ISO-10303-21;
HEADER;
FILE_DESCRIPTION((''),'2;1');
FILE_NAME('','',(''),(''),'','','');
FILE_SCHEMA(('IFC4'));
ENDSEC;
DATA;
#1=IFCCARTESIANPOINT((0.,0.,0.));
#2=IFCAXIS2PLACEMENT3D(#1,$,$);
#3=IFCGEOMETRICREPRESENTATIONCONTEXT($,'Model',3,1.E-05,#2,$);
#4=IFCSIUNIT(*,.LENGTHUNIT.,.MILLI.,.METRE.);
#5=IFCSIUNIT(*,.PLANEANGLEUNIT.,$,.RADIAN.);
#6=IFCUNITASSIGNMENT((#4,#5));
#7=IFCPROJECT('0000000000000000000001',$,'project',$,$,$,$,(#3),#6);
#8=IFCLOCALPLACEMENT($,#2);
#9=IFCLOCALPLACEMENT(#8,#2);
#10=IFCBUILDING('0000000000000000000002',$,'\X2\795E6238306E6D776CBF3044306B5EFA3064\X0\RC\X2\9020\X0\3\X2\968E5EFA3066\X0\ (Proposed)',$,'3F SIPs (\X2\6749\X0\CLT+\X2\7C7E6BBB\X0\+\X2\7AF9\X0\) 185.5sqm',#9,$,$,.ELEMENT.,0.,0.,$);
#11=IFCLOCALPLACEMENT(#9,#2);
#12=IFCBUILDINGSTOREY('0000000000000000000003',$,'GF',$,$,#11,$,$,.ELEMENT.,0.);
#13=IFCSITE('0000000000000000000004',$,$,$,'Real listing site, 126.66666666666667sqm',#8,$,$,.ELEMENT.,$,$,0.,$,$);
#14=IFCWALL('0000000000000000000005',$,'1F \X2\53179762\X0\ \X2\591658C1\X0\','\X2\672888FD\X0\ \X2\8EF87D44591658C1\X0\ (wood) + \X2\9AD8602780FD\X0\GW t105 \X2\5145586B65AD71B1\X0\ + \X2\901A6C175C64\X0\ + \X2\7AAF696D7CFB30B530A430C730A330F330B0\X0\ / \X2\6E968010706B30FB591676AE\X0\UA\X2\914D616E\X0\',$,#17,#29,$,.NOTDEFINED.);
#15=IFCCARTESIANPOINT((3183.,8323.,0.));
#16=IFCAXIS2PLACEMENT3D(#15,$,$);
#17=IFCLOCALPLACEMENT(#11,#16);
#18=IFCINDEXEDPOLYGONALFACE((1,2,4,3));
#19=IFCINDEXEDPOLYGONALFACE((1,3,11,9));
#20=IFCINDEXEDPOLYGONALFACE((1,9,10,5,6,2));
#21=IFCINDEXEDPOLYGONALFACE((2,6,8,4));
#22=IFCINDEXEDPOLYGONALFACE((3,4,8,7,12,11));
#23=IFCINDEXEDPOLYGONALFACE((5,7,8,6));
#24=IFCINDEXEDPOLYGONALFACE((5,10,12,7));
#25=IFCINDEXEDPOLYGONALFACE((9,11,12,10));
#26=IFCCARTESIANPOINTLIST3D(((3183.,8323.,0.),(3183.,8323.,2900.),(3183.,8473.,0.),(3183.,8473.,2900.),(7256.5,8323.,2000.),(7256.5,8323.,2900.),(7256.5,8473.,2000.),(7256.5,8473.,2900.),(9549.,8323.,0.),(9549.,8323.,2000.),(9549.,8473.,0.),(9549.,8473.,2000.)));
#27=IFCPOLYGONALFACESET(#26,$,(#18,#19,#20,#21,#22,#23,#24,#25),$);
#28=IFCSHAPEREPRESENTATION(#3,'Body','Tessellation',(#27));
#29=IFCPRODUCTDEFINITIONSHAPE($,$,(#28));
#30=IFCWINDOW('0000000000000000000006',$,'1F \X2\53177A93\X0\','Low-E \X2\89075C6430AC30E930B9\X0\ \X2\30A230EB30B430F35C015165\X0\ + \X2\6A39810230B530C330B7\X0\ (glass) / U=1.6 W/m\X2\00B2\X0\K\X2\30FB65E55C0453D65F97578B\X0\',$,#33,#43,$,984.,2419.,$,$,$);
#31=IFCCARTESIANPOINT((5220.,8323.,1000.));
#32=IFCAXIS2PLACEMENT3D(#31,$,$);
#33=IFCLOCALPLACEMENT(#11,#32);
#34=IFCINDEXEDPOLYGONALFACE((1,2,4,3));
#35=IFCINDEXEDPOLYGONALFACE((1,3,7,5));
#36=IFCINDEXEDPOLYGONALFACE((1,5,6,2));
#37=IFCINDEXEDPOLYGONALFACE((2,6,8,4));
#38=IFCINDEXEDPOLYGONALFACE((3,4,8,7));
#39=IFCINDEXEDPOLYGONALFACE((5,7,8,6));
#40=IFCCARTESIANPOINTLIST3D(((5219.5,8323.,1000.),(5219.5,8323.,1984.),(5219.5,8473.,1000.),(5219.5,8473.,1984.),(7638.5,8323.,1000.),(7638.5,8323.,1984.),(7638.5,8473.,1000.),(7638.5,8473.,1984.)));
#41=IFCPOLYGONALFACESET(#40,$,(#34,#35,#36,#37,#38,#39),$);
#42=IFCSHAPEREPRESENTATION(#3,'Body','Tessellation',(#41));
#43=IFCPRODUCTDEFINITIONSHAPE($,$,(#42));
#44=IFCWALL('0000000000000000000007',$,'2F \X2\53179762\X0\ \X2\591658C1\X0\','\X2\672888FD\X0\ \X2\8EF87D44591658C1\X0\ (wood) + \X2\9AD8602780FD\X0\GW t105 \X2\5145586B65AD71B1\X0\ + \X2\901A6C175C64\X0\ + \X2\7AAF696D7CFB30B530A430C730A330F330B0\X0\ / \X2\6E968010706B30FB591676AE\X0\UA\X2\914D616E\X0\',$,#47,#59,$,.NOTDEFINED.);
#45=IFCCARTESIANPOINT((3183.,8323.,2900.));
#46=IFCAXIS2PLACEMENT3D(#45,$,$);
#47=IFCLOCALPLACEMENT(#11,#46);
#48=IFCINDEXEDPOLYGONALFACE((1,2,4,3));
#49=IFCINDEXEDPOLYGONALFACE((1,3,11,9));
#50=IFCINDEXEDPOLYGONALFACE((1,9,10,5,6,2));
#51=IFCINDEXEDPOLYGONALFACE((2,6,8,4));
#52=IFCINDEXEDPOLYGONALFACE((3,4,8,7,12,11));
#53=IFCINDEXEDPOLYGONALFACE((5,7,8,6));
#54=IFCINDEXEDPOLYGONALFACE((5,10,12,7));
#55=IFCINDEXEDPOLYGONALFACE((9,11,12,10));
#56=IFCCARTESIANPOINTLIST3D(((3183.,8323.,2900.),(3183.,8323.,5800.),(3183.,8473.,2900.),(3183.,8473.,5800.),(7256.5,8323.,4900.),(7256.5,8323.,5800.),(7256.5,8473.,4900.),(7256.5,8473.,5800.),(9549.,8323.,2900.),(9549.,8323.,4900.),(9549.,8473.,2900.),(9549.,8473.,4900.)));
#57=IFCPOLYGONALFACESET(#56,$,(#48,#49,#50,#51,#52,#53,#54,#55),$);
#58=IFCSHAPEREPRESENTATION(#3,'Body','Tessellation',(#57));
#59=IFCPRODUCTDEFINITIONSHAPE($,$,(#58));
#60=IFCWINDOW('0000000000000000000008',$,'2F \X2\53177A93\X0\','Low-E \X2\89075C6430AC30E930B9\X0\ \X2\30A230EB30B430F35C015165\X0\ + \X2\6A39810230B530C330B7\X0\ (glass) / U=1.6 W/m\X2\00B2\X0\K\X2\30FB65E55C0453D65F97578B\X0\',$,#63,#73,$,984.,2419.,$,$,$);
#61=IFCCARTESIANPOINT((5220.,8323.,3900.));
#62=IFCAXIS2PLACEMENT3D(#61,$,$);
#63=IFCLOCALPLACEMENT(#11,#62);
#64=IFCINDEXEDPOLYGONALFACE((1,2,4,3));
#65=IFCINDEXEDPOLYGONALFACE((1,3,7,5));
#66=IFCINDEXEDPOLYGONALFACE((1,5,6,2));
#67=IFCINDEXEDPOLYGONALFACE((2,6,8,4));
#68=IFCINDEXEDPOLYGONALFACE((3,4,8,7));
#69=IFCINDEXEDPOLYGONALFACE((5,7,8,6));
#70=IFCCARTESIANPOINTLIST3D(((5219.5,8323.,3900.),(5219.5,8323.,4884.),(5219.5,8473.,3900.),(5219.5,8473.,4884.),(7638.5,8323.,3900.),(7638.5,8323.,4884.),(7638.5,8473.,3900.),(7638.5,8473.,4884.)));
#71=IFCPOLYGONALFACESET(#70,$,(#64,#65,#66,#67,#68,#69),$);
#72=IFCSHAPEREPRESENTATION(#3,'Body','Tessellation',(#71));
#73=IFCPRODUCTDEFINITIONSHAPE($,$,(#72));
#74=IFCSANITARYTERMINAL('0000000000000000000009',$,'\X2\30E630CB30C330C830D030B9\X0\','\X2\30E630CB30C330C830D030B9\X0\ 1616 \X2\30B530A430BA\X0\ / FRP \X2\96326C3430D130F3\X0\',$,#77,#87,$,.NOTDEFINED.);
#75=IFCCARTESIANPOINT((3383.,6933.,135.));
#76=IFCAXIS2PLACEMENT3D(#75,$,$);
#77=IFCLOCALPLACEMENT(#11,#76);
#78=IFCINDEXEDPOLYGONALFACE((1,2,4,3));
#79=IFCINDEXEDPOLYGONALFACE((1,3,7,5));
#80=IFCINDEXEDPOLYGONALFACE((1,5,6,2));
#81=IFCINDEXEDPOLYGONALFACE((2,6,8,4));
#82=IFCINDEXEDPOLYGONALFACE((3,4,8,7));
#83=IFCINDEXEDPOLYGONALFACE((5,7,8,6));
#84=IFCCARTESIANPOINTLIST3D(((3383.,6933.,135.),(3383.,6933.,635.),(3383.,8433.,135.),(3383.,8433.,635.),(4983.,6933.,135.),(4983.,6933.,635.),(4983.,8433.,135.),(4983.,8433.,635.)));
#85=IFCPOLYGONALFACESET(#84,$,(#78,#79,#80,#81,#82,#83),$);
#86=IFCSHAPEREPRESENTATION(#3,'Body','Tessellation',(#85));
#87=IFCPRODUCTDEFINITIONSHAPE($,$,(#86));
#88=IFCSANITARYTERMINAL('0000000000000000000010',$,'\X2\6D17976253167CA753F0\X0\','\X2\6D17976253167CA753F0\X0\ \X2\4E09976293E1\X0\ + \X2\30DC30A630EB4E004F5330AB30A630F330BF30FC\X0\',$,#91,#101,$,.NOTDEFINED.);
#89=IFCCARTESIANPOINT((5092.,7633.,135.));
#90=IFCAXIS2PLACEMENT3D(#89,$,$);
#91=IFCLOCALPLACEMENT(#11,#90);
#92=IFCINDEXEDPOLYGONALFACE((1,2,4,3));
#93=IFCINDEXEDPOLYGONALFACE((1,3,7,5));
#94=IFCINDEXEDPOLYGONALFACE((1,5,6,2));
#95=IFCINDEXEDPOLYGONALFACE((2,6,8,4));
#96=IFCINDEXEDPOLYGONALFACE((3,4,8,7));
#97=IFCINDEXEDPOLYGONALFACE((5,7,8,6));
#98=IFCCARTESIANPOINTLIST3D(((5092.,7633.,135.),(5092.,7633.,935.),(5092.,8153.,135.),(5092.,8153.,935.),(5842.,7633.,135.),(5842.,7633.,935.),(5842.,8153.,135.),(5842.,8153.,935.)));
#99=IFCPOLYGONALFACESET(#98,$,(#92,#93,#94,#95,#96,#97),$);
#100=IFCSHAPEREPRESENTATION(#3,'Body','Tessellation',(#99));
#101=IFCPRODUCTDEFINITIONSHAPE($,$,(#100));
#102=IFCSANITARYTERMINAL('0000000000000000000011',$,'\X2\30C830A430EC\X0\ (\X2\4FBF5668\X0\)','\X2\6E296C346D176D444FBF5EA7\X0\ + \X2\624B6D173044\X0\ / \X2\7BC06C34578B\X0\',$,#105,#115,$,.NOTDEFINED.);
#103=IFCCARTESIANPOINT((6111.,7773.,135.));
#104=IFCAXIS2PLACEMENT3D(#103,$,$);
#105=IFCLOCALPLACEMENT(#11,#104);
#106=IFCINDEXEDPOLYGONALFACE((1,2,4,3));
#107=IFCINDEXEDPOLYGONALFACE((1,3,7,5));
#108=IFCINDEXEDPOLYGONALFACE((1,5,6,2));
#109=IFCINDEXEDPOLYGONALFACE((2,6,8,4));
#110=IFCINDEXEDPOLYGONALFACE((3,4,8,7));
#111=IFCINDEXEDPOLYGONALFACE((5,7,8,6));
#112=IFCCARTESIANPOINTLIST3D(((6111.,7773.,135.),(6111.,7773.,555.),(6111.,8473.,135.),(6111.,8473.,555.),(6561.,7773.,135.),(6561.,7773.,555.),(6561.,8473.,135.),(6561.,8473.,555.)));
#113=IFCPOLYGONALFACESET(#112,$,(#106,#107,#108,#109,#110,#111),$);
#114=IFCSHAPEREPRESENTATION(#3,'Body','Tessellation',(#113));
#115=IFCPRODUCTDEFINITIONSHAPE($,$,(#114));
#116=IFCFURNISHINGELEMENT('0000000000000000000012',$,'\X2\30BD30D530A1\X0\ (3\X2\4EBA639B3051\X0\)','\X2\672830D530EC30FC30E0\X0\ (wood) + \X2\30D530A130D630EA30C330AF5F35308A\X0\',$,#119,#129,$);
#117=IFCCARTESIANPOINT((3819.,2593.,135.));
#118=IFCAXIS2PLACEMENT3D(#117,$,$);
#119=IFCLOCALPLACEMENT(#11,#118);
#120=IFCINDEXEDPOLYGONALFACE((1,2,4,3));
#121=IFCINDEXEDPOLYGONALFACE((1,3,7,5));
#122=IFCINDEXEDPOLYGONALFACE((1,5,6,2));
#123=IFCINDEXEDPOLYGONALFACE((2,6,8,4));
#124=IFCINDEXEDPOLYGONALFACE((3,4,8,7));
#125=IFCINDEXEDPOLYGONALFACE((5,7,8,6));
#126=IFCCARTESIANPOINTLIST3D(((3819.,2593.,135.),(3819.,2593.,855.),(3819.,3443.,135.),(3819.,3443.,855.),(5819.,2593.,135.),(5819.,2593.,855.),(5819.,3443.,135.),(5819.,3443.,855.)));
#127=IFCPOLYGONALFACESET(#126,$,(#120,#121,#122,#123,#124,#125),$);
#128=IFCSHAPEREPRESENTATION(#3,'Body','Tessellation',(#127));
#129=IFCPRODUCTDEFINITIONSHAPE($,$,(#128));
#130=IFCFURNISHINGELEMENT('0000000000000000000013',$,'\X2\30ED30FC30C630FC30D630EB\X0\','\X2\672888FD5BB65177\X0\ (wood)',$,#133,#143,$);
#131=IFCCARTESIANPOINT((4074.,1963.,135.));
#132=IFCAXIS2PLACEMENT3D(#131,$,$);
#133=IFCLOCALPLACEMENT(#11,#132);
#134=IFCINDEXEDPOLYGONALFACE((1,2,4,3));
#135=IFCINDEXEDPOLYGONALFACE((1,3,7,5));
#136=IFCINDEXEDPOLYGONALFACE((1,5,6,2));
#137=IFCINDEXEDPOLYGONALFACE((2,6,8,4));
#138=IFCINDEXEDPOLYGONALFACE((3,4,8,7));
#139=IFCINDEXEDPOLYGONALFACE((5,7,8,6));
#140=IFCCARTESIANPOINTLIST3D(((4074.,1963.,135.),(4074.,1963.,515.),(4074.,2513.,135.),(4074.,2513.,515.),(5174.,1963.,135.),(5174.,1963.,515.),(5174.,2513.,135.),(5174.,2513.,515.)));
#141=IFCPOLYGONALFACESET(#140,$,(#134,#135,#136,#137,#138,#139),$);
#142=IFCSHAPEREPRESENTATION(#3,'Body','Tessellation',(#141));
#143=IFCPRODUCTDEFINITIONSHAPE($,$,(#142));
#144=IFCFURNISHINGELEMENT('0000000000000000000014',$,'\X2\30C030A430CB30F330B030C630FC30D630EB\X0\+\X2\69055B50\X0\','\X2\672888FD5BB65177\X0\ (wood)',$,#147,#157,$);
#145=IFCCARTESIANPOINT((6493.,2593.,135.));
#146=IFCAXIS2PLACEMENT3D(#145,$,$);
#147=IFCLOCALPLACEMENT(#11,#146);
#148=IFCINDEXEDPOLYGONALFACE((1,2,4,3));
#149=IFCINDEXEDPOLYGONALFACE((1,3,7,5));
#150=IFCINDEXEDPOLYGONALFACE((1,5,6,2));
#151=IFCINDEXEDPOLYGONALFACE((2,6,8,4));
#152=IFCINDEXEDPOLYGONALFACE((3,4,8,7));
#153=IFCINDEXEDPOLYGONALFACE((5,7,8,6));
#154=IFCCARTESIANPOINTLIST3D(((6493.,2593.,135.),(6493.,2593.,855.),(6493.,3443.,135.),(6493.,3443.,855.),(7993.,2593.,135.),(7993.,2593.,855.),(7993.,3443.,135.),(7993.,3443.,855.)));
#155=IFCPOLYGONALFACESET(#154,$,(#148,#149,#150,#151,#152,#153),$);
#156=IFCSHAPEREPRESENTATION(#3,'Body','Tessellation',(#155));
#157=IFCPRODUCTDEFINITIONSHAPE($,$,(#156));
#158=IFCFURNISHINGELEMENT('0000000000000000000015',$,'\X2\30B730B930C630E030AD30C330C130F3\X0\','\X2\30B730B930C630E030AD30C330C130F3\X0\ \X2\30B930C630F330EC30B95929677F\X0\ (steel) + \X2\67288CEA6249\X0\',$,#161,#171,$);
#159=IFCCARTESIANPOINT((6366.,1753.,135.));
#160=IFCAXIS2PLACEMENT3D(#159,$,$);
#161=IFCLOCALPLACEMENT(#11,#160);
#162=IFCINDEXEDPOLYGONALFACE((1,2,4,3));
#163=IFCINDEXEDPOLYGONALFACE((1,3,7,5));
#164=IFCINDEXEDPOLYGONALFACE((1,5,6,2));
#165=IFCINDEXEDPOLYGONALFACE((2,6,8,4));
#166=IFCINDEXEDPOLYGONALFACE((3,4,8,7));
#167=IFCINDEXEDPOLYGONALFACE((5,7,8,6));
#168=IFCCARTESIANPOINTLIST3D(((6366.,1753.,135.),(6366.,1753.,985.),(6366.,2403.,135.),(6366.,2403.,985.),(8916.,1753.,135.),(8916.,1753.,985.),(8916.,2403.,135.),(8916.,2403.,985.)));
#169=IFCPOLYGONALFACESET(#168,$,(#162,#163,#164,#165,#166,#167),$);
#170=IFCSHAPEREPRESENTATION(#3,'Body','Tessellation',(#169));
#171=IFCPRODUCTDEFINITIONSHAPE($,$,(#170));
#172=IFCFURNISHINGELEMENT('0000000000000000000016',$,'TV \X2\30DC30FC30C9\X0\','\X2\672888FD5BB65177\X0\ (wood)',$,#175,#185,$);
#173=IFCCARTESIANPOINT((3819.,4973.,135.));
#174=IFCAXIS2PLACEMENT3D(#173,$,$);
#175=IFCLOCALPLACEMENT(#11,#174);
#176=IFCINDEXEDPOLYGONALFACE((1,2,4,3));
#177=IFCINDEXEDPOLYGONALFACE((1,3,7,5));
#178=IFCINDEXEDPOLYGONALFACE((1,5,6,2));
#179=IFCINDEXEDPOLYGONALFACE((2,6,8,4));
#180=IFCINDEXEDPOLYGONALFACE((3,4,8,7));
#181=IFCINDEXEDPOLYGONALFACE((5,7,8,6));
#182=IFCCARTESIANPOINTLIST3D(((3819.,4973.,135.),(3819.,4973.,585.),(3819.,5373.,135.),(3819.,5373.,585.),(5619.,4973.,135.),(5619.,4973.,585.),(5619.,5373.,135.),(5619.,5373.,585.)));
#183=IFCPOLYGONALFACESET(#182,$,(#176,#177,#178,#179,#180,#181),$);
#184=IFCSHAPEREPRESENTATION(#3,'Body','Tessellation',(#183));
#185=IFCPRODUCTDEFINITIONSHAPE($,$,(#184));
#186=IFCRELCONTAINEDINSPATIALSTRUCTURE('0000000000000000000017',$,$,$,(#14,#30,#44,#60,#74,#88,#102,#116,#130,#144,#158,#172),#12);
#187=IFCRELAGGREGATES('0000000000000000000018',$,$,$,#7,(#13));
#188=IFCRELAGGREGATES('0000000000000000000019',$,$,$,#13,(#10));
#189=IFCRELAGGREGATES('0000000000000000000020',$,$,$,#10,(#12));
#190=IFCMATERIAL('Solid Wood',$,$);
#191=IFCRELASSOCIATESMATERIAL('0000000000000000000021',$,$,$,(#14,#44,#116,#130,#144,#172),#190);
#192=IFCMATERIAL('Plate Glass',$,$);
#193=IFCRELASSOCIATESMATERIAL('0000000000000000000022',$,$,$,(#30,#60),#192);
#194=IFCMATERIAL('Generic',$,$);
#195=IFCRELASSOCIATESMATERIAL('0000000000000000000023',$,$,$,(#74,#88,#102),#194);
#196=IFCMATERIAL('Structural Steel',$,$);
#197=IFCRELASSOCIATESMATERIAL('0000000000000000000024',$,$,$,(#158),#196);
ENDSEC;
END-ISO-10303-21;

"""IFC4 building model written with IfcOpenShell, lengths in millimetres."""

from ifc_helpers import new_model, si_unit, frame, frame_2d, origin, place, context, project, spatial, rectangle, extrude, material, element, fill, save


model = new_model("IFC4")

# Units and contexts
model_context = context("Model", 3, precision=1e-05, world=origin())
ifc_project = project(units=[si_unit("LENGTHUNIT", "METRE", prefix="MILLI"), si_unit("PLANEANGLEUNIT", "RADIAN")], contexts=[model_context])

# Site, building, storey
site_placement = place(None, origin())
site = spatial("IfcSite", under=ifc_project, at=site_placement, ObjectType="Real listing site, 126.66666666666667sqm", CompositionType="ELEMENT", RefElevation=0.0)
building_placement = place(site_placement, origin())
building = spatial("IfcBuilding", under=site, at=building_placement, Name="神戸の海沿いに建つRC造3階建て (Proposed)", ObjectType="3F SIPs (杉CLT+籾殻+竹) 185.5sqm", CompositionType="ELEMENT", ElevationOfRefHeight=0.0, ElevationOfTerrain=0.0)
storey_placement = place(building_placement, origin())
storey = spatial("IfcBuildingStorey", under=building, at=storey_placement, Name="GF", CompositionType="ELEMENT", Elevation=0.0)

# Wall, opening, window
ifc_material_1 = material(Name="Solid Wood")
wall_1_placement = place(storey_placement, frame((3183.0, 8323.0, 0.0)))
wall_1 = element("IfcWall", 1, at=wall_1_placement, inside=storey, material=ifc_material_1, Name="1F 北面 外壁", Description="木製 軸組外壁 (wood) + 高性能GW t105 充填断熱 + 通気層 + 窯業系サイディング / 準耐火・外皮UA配慮", PredefinedType="NOTDEFINED", context=model_context, shape_type="SweptSolid", body=[
    extrude(rectangle(XDim=6366.0, YDim=150.0, at=frame_2d((3183.0, 75.0))), frame((3183.0, 8323.0, 0.0)), (0.0, 0.0, 1.0), 2900.0),
])
opening_1_placement = place(storey_placement, frame((5220.0, 8323.0, 1000.0)))
opening_1 = element("IfcOpeningElement", 2, at=opening_1_placement, cuts=wall_1, PredefinedType="NOTDEFINED", context=model_context, shape_type="SweptSolid", body=[
    extrude(rectangle(XDim=2419.0, YDim=150.0, at=frame_2d((1209.0, 75.0))), frame((5220.0, 8323.0, 1000.0)), (0.0, 0.0, 1.0), 984.0),
])
ifc_material_2 = material(Name="Plate Glass")
window_1_placement = place(storey_placement, frame((5220.0, 8323.0, 1000.0)))
window_1 = element("IfcWindow", 3, at=window_1_placement, inside=storey, material=ifc_material_2, Name="1F 北窓", Description="Low-E 複層ガラス アルゴン封入 + 樹脂サッシ (glass) / U=1.6 W/m²K・日射取得型", OverallHeight=984.0, OverallWidth=2419.0, context=model_context, shape_type="SweptSolid", body=[
    extrude(rectangle(XDim=2419.0, YDim=150.0, at=frame_2d((1209.0, 75.0))), frame((5220.0, 8323.0, 1000.0)), (0.0, 0.0, 1.0), 984.0),
])
fill(opening_1, window_1)

# Wall, opening, window
wall_2_placement = place(storey_placement, frame((3183.0, 8323.0, 2900.0)))
wall_2 = element("IfcWall", 4, at=wall_2_placement, inside=storey, material=ifc_material_1, Name="2F 北面 外壁", Description="木製 軸組外壁 (wood) + 高性能GW t105 充填断熱 + 通気層 + 窯業系サイディング / 準耐火・外皮UA配慮", PredefinedType="NOTDEFINED", context=model_context, shape_type="SweptSolid", body=[
    extrude(rectangle(XDim=6366.0, YDim=150.0, at=frame_2d((3183.0, 75.0))), frame((3183.0, 8323.0, 2900.0)), (0.0, 0.0, 1.0), 2900.0),
])
opening_2_placement = place(storey_placement, frame((5220.0, 8323.0, 3900.0)))
opening_2 = element("IfcOpeningElement", 5, at=opening_2_placement, cuts=wall_2, PredefinedType="NOTDEFINED", context=model_context, shape_type="SweptSolid", body=[
    extrude(rectangle(XDim=2419.0, YDim=150.0, at=frame_2d((1209.0, 75.0))), frame((5220.0, 8323.0, 3900.0)), (0.0, 0.0, 1.0), 984.0),
])
window_2_placement = place(storey_placement, frame((5220.0, 8323.0, 3900.0)))
window_2 = element("IfcWindow", 6, at=window_2_placement, inside=storey, material=ifc_material_2, Name="2F 北窓", Description="Low-E 複層ガラス アルゴン封入 + 樹脂サッシ (glass) / U=1.6 W/m²K・日射取得型", OverallHeight=984.0, OverallWidth=2419.0, context=model_context, shape_type="SweptSolid", body=[
    extrude(rectangle(XDim=2419.0, YDim=150.0, at=frame_2d((1209.0, 75.0))), frame((5220.0, 8323.0, 3900.0)), (0.0, 0.0, 1.0), 984.0),
])
fill(opening_2, window_2)

# Sanitary terminals
ifc_material_3 = material(Name="Generic")
sanitary_terminal_1_placement = place(storey_placement, frame((3383.0, 6933.0, 135.0)))
element("IfcSanitaryTerminal", 7, at=sanitary_terminal_1_placement, inside=storey, material=ifc_material_3, Name="ユニットバス", Description="ユニットバス 1616 サイズ / FRP 防水パン", PredefinedType="NOTDEFINED", context=model_context, shape_type="SweptSolid", body=[
    extrude(rectangle(XDim=1600.0, YDim=1500.0, at=frame_2d((800.0, 750.0))), frame((3383.0, 6933.0, 135.0)), (0.0, 0.0, 1.0), 500.0),
])
sanitary_terminal_2_placement = place(storey_placement, frame((5092.0, 7633.0, 135.0)))
element("IfcSanitaryTerminal", 8, at=sanitary_terminal_2_placement, inside=storey, material=ifc_material_3, Name="洗面化粧台", Description="洗面化粧台 三面鏡 + ボウル一体カウンター", PredefinedType="NOTDEFINED", context=model_context, shape_type="SweptSolid", body=[
    extrude(rectangle(XDim=750.0, YDim=520.0, at=frame_2d((375.0, 260.0))), frame((5092.0, 7633.0, 135.0)), (0.0, 0.0, 1.0), 800.0),
])
sanitary_terminal_3_placement = place(storey_placement, frame((6111.0, 7773.0, 135.0)))
element("IfcSanitaryTerminal", 9, at=sanitary_terminal_3_placement, inside=storey, material=ifc_material_3, Name="トイレ (便器)", Description="温水洗浄便座 + 手洗い / 節水型", PredefinedType="NOTDEFINED", context=model_context, shape_type="SweptSolid", body=[
    extrude(rectangle(XDim=450.0, YDim=700.0, at=frame_2d((225.0, 350.0))), frame((6111.0, 7773.0, 135.0)), (0.0, 0.0, 1.0), 420.0),
])

# Furnishing elements
furnishing_1_placement = place(storey_placement, frame((3819.0, 2593.0, 135.0)))
element("IfcFurnishingElement", 10, at=furnishing_1_placement, inside=storey, material=ifc_material_1, Name="ソファ (3人掛け)", Description="木フレーム (wood) + ファブリック張り", context=model_context, shape_type="SweptSolid", body=[
    extrude(rectangle(XDim=2000.0, YDim=850.0, at=frame_2d((1000.0, 425.0))), frame((3819.0, 2593.0, 135.0)), (0.0, 0.0, 1.0), 720.0),
])
furnishing_2_placement = place(storey_placement, frame((4074.0, 1963.0, 135.0)))
element("IfcFurnishingElement", 11, at=furnishing_2_placement, inside=storey, material=ifc_material_1, Name="ローテーブル", Description="木製家具 (wood)", context=model_context, shape_type="SweptSolid", body=[
    extrude(rectangle(XDim=1100.0, YDim=550.0, at=frame_2d((550.0, 275.0))), frame((4074.0, 1963.0, 135.0)), (0.0, 0.0, 1.0), 380.0),
])
furnishing_3_placement = place(storey_placement, frame((6493.0, 2593.0, 135.0)))
element("IfcFurnishingElement", 12, at=furnishing_3_placement, inside=storey, material=ifc_material_1, Name="ダイニングテーブル+椅子", Description="木製家具 (wood)", context=model_context, shape_type="SweptSolid", body=[
    extrude(rectangle(XDim=1500.0, YDim=850.0, at=frame_2d((750.0, 425.0))), frame((6493.0, 2593.0, 135.0)), (0.0, 0.0, 1.0), 720.0),
])
ifc_material_4 = material(Name="Structural Steel")
furnishing_4_placement = place(storey_placement, frame((6366.0, 1753.0, 135.0)))
element("IfcFurnishingElement", 13, at=furnishing_4_placement, inside=storey, material=ifc_material_4, Name="システムキッチン", Description="システムキッチン ステンレス天板 (steel) + 木質扉", context=model_context, shape_type="SweptSolid", body=[
    extrude(rectangle(XDim=2550.0, YDim=650.0, at=frame_2d((1275.0, 325.0))), frame((6366.0, 1753.0, 135.0)), (0.0, 0.0, 1.0), 850.0),
])
furnishing_5_placement = place(storey_placement, frame((3819.0, 4973.0, 135.0)))
element("IfcFurnishingElement", 14, at=furnishing_5_placement, inside=storey, material=ifc_material_1, Name="TV ボード", Description="木製家具 (wood)", context=model_context, shape_type="SweptSolid", body=[
    extrude(rectangle(XDim=1800.0, YDim=400.0, at=frame_2d((900.0, 200.0))), frame((3819.0, 4973.0, 135.0)), (0.0, 0.0, 1.0), 450.0),
])

save(model, "model.ifc")
